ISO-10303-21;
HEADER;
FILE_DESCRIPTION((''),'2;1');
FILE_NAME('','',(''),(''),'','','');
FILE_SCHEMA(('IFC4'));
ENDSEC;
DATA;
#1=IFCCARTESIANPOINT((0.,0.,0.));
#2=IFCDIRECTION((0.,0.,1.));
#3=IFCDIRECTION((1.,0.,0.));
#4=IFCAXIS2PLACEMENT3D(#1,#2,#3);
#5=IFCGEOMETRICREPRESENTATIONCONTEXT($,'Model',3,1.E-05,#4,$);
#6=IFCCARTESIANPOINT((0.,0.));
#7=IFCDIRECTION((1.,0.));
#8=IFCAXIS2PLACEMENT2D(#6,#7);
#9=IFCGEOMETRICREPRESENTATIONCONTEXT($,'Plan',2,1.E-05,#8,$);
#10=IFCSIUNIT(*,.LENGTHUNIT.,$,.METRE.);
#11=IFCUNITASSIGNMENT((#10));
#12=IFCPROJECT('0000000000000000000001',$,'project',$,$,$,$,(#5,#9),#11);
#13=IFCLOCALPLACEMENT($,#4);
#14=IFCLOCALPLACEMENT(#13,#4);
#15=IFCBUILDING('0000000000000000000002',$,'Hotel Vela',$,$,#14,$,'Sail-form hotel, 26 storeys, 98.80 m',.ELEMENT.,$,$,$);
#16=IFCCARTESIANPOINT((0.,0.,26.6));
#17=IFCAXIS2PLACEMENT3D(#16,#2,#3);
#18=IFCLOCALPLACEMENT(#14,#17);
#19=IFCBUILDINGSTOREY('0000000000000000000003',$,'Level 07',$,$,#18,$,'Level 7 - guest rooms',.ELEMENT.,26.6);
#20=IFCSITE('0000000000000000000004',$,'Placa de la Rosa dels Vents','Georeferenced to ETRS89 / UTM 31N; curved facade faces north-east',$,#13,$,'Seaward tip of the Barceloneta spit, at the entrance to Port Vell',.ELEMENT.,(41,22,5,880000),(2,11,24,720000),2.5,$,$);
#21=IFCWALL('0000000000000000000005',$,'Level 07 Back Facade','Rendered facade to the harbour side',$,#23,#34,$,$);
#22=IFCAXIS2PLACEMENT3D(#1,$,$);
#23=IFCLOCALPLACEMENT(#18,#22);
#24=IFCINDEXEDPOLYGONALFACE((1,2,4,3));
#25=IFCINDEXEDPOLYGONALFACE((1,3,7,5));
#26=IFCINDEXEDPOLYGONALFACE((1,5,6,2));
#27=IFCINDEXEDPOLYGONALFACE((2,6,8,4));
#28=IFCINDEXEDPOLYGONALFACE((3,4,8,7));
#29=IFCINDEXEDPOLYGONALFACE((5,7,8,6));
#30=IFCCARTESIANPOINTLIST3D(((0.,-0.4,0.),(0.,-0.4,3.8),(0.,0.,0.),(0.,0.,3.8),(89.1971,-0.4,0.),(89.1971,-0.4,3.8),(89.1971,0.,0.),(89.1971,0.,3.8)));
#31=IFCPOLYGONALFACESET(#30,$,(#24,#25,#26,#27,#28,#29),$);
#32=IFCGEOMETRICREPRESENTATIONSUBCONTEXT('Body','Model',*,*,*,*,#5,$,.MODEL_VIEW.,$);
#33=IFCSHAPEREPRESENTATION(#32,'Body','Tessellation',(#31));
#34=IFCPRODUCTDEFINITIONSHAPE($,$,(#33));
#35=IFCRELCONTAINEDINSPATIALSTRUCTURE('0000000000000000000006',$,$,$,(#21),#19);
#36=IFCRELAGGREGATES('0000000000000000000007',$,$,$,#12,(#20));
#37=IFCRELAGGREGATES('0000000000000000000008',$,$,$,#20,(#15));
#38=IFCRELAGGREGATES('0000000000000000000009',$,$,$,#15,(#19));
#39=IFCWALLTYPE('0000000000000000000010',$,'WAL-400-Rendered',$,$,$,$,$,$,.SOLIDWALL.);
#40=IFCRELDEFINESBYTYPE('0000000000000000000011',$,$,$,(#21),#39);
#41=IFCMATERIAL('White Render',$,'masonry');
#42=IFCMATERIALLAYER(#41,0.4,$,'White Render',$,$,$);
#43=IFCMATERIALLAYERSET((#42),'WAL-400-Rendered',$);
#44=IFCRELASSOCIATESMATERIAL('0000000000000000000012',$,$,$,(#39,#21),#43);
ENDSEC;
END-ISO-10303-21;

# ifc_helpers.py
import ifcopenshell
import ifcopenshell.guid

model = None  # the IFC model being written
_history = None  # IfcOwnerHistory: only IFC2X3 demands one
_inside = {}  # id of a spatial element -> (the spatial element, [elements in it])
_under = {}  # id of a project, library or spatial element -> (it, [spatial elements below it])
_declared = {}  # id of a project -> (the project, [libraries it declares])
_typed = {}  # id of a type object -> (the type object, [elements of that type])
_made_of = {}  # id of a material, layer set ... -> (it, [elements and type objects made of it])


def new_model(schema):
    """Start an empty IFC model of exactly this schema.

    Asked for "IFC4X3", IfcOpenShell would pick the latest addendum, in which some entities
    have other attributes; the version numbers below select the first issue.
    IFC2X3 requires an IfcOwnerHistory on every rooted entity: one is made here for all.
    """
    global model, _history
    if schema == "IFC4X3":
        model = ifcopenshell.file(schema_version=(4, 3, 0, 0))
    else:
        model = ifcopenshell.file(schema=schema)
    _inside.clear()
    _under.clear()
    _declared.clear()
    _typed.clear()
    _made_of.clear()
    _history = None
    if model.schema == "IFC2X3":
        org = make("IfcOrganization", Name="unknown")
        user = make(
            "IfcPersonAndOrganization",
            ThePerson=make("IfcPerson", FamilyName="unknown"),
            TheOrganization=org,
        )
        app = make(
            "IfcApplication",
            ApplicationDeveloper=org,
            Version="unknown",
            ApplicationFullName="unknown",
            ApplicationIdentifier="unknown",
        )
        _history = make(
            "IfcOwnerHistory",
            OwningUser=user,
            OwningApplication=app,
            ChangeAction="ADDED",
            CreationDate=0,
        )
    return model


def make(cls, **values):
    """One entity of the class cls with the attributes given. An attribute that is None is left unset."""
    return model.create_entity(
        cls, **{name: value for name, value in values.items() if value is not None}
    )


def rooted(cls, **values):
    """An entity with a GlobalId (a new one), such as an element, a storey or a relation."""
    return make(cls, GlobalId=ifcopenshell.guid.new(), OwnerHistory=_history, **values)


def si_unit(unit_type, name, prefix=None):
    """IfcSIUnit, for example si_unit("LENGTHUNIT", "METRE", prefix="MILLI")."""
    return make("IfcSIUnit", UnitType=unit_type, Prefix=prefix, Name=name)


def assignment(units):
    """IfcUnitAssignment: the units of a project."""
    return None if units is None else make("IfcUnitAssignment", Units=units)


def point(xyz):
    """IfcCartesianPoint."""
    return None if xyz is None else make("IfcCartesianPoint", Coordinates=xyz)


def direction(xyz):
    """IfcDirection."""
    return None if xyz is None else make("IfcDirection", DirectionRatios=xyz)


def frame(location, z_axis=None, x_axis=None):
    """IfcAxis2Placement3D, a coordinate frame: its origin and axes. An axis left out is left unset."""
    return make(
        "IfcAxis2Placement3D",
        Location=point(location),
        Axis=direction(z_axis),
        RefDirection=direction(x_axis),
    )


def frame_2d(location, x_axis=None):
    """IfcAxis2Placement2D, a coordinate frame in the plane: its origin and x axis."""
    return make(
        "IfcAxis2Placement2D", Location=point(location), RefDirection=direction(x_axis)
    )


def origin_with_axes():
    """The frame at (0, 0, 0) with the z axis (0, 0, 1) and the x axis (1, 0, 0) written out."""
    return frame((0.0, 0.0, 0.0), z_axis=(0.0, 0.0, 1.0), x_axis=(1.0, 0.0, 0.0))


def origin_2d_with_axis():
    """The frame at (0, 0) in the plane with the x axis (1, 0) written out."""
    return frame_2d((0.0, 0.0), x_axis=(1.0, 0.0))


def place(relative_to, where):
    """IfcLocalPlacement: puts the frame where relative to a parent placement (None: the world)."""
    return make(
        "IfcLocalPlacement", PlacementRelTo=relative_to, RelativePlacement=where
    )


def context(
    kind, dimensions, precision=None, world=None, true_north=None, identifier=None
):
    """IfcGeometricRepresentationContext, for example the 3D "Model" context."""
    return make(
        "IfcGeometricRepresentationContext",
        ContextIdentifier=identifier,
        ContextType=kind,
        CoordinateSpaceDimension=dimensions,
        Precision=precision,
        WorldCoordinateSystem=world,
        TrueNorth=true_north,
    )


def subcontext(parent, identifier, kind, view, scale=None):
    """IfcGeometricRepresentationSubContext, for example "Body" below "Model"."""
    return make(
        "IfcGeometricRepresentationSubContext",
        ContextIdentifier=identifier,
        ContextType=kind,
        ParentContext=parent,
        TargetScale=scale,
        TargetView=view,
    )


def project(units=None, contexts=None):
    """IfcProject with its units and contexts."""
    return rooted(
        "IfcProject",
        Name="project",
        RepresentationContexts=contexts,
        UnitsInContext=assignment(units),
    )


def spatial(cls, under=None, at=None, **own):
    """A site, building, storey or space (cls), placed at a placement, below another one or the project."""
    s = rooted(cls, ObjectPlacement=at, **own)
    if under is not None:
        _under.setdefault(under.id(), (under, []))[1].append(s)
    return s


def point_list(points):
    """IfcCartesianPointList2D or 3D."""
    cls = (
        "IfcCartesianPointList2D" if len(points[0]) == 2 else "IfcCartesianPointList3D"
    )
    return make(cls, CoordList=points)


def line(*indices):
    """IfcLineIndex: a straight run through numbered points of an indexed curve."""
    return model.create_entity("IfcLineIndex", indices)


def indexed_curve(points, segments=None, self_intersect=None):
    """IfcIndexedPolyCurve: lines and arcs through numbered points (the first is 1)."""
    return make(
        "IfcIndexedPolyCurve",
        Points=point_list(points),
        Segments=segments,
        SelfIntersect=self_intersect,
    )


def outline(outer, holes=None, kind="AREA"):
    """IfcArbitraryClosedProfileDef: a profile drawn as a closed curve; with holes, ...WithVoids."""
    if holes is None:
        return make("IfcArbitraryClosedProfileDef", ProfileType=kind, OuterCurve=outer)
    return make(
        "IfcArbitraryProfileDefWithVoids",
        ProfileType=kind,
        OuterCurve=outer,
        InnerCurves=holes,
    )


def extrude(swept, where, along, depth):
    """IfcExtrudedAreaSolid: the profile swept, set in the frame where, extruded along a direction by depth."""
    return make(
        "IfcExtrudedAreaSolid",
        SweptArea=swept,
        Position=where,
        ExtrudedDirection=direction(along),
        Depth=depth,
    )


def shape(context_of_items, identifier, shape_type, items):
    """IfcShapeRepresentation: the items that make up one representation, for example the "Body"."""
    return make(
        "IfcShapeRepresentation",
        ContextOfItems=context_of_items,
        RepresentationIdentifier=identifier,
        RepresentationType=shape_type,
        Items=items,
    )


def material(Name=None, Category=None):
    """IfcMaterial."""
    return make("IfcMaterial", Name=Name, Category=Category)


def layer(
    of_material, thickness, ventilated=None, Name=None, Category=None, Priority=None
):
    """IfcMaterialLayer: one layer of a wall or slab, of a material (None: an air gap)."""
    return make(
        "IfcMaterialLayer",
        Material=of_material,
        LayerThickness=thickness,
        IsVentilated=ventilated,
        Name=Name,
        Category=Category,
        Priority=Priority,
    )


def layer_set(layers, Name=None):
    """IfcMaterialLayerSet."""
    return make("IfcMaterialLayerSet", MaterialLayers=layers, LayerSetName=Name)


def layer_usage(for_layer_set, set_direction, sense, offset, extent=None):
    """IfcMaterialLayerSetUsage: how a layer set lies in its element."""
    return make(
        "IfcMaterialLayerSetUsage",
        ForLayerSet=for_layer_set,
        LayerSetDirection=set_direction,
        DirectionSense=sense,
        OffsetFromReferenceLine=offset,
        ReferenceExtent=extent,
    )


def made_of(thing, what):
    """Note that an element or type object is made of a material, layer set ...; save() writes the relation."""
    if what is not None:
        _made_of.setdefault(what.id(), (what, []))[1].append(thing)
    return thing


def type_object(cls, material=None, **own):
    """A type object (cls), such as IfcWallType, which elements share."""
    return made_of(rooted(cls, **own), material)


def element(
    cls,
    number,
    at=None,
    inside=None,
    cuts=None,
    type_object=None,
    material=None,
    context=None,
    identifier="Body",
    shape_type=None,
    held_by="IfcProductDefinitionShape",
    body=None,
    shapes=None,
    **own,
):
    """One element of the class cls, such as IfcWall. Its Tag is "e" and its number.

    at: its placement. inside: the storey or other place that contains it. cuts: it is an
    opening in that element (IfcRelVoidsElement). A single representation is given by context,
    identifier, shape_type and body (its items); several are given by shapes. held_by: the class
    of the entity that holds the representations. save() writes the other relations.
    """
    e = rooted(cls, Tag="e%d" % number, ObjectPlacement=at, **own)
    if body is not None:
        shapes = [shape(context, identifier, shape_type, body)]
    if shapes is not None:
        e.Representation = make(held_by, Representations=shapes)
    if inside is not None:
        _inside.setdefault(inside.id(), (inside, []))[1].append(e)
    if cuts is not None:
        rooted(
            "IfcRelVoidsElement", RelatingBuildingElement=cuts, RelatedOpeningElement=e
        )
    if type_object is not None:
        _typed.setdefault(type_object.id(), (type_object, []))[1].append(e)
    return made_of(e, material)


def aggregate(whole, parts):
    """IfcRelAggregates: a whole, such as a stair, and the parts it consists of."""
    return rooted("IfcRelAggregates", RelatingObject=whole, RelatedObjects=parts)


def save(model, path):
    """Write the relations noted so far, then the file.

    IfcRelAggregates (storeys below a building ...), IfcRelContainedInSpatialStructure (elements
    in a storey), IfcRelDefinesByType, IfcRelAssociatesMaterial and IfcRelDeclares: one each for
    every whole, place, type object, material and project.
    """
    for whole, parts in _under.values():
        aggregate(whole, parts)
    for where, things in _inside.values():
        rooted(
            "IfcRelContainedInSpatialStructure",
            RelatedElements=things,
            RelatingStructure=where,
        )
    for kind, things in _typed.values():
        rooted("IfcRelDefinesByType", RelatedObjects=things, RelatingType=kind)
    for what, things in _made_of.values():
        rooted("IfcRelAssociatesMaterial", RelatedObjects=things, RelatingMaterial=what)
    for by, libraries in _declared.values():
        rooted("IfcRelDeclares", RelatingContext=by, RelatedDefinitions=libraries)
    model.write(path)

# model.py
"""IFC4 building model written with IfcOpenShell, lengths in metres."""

from ifc_helpers import new_model, si_unit, frame, origin_with_axes, origin_2d_with_axis, place, context, subcontext, project, spatial, line, indexed_curve, outline, extrude, material, layer, layer_set, layer_usage, type_object, element, save


model = new_model("IFC4")

# Units and contexts
model_context = context("Model", 3, precision=1e-05, world=origin_with_axes())
plan_context = context("Plan", 2, precision=1e-05, world=origin_2d_with_axis())
body_context = subcontext(model_context, "Body", "Model", "MODEL_VIEW")
ifc_project = project(units=[si_unit("LENGTHUNIT", "METRE")], contexts=[model_context, plan_context])

# Site, building, storey
site_placement = place(None, origin_with_axes())
site = spatial("IfcSite", under=ifc_project, at=site_placement, Name="Placa de la Rosa dels Vents", Description="Georeferenced to ETRS89 / UTM 31N; curved facade faces north-east", LongName="Seaward tip of the Barceloneta spit, at the entrance to Port Vell", CompositionType="ELEMENT", RefLatitude=(41, 22, 5, 880000), RefLongitude=(2, 11, 24, 720000), RefElevation=2.5)
building_placement = place(site_placement, origin_with_axes())
building = spatial("IfcBuilding", under=site, at=building_placement, Name="Hotel Vela", LongName="Sail-form hotel, 26 storeys, 98.80 m", CompositionType="ELEMENT")
storey_placement = place(building_placement, frame((0.0, 0.0, 26.6), z_axis=(0.0, 0.0, 1.0), x_axis=(1.0, 0.0, 0.0)))
storey = spatial("IfcBuildingStorey", under=building, at=storey_placement, Name="Level 07", LongName="Level 7 - guest rooms", CompositionType="ELEMENT", Elevation=26.6)

# Wall
ifc_material_1 = material(Name="White Render", Category="masonry")
ifc_layer_1 = layer(ifc_material_1, 0.4, Name="White Render")
ifc_layer_set_1 = layer_set([ifc_layer_1], Name="WAL-400-Rendered")
ifc_layer_usage_1 = layer_usage(ifc_layer_set_1, "AXIS2", "POSITIVE", 0.0)
wall_type = type_object("IfcWallType", Name="WAL-400-Rendered", PredefinedType="SOLIDWALL", material=ifc_layer_set_1)
wall_placement = place(storey_placement, frame((0.0, -0.4, 0.0), z_axis=(0.0, 0.0, 1.0), x_axis=(1.0, 0.0, 0.0)))
element("IfcWall", 1, at=wall_placement, inside=storey, type_object=wall_type, material=ifc_layer_usage_1, Name="Level 07 Back Facade", Description="Rendered facade to the harbour side", context=body_context, shape_type="SweptSolid", body=[
    extrude(outline(indexed_curve([(0.0, 0.0), (89.1971, 0.0), (89.1971, 0.4), (0.0, 0.4)], segments=[line(1, 2, 3, 4, 1)])), origin_with_axes(), (0.0, 0.0, 1.0), 3.8),
])

save(model, "model.ifc")
